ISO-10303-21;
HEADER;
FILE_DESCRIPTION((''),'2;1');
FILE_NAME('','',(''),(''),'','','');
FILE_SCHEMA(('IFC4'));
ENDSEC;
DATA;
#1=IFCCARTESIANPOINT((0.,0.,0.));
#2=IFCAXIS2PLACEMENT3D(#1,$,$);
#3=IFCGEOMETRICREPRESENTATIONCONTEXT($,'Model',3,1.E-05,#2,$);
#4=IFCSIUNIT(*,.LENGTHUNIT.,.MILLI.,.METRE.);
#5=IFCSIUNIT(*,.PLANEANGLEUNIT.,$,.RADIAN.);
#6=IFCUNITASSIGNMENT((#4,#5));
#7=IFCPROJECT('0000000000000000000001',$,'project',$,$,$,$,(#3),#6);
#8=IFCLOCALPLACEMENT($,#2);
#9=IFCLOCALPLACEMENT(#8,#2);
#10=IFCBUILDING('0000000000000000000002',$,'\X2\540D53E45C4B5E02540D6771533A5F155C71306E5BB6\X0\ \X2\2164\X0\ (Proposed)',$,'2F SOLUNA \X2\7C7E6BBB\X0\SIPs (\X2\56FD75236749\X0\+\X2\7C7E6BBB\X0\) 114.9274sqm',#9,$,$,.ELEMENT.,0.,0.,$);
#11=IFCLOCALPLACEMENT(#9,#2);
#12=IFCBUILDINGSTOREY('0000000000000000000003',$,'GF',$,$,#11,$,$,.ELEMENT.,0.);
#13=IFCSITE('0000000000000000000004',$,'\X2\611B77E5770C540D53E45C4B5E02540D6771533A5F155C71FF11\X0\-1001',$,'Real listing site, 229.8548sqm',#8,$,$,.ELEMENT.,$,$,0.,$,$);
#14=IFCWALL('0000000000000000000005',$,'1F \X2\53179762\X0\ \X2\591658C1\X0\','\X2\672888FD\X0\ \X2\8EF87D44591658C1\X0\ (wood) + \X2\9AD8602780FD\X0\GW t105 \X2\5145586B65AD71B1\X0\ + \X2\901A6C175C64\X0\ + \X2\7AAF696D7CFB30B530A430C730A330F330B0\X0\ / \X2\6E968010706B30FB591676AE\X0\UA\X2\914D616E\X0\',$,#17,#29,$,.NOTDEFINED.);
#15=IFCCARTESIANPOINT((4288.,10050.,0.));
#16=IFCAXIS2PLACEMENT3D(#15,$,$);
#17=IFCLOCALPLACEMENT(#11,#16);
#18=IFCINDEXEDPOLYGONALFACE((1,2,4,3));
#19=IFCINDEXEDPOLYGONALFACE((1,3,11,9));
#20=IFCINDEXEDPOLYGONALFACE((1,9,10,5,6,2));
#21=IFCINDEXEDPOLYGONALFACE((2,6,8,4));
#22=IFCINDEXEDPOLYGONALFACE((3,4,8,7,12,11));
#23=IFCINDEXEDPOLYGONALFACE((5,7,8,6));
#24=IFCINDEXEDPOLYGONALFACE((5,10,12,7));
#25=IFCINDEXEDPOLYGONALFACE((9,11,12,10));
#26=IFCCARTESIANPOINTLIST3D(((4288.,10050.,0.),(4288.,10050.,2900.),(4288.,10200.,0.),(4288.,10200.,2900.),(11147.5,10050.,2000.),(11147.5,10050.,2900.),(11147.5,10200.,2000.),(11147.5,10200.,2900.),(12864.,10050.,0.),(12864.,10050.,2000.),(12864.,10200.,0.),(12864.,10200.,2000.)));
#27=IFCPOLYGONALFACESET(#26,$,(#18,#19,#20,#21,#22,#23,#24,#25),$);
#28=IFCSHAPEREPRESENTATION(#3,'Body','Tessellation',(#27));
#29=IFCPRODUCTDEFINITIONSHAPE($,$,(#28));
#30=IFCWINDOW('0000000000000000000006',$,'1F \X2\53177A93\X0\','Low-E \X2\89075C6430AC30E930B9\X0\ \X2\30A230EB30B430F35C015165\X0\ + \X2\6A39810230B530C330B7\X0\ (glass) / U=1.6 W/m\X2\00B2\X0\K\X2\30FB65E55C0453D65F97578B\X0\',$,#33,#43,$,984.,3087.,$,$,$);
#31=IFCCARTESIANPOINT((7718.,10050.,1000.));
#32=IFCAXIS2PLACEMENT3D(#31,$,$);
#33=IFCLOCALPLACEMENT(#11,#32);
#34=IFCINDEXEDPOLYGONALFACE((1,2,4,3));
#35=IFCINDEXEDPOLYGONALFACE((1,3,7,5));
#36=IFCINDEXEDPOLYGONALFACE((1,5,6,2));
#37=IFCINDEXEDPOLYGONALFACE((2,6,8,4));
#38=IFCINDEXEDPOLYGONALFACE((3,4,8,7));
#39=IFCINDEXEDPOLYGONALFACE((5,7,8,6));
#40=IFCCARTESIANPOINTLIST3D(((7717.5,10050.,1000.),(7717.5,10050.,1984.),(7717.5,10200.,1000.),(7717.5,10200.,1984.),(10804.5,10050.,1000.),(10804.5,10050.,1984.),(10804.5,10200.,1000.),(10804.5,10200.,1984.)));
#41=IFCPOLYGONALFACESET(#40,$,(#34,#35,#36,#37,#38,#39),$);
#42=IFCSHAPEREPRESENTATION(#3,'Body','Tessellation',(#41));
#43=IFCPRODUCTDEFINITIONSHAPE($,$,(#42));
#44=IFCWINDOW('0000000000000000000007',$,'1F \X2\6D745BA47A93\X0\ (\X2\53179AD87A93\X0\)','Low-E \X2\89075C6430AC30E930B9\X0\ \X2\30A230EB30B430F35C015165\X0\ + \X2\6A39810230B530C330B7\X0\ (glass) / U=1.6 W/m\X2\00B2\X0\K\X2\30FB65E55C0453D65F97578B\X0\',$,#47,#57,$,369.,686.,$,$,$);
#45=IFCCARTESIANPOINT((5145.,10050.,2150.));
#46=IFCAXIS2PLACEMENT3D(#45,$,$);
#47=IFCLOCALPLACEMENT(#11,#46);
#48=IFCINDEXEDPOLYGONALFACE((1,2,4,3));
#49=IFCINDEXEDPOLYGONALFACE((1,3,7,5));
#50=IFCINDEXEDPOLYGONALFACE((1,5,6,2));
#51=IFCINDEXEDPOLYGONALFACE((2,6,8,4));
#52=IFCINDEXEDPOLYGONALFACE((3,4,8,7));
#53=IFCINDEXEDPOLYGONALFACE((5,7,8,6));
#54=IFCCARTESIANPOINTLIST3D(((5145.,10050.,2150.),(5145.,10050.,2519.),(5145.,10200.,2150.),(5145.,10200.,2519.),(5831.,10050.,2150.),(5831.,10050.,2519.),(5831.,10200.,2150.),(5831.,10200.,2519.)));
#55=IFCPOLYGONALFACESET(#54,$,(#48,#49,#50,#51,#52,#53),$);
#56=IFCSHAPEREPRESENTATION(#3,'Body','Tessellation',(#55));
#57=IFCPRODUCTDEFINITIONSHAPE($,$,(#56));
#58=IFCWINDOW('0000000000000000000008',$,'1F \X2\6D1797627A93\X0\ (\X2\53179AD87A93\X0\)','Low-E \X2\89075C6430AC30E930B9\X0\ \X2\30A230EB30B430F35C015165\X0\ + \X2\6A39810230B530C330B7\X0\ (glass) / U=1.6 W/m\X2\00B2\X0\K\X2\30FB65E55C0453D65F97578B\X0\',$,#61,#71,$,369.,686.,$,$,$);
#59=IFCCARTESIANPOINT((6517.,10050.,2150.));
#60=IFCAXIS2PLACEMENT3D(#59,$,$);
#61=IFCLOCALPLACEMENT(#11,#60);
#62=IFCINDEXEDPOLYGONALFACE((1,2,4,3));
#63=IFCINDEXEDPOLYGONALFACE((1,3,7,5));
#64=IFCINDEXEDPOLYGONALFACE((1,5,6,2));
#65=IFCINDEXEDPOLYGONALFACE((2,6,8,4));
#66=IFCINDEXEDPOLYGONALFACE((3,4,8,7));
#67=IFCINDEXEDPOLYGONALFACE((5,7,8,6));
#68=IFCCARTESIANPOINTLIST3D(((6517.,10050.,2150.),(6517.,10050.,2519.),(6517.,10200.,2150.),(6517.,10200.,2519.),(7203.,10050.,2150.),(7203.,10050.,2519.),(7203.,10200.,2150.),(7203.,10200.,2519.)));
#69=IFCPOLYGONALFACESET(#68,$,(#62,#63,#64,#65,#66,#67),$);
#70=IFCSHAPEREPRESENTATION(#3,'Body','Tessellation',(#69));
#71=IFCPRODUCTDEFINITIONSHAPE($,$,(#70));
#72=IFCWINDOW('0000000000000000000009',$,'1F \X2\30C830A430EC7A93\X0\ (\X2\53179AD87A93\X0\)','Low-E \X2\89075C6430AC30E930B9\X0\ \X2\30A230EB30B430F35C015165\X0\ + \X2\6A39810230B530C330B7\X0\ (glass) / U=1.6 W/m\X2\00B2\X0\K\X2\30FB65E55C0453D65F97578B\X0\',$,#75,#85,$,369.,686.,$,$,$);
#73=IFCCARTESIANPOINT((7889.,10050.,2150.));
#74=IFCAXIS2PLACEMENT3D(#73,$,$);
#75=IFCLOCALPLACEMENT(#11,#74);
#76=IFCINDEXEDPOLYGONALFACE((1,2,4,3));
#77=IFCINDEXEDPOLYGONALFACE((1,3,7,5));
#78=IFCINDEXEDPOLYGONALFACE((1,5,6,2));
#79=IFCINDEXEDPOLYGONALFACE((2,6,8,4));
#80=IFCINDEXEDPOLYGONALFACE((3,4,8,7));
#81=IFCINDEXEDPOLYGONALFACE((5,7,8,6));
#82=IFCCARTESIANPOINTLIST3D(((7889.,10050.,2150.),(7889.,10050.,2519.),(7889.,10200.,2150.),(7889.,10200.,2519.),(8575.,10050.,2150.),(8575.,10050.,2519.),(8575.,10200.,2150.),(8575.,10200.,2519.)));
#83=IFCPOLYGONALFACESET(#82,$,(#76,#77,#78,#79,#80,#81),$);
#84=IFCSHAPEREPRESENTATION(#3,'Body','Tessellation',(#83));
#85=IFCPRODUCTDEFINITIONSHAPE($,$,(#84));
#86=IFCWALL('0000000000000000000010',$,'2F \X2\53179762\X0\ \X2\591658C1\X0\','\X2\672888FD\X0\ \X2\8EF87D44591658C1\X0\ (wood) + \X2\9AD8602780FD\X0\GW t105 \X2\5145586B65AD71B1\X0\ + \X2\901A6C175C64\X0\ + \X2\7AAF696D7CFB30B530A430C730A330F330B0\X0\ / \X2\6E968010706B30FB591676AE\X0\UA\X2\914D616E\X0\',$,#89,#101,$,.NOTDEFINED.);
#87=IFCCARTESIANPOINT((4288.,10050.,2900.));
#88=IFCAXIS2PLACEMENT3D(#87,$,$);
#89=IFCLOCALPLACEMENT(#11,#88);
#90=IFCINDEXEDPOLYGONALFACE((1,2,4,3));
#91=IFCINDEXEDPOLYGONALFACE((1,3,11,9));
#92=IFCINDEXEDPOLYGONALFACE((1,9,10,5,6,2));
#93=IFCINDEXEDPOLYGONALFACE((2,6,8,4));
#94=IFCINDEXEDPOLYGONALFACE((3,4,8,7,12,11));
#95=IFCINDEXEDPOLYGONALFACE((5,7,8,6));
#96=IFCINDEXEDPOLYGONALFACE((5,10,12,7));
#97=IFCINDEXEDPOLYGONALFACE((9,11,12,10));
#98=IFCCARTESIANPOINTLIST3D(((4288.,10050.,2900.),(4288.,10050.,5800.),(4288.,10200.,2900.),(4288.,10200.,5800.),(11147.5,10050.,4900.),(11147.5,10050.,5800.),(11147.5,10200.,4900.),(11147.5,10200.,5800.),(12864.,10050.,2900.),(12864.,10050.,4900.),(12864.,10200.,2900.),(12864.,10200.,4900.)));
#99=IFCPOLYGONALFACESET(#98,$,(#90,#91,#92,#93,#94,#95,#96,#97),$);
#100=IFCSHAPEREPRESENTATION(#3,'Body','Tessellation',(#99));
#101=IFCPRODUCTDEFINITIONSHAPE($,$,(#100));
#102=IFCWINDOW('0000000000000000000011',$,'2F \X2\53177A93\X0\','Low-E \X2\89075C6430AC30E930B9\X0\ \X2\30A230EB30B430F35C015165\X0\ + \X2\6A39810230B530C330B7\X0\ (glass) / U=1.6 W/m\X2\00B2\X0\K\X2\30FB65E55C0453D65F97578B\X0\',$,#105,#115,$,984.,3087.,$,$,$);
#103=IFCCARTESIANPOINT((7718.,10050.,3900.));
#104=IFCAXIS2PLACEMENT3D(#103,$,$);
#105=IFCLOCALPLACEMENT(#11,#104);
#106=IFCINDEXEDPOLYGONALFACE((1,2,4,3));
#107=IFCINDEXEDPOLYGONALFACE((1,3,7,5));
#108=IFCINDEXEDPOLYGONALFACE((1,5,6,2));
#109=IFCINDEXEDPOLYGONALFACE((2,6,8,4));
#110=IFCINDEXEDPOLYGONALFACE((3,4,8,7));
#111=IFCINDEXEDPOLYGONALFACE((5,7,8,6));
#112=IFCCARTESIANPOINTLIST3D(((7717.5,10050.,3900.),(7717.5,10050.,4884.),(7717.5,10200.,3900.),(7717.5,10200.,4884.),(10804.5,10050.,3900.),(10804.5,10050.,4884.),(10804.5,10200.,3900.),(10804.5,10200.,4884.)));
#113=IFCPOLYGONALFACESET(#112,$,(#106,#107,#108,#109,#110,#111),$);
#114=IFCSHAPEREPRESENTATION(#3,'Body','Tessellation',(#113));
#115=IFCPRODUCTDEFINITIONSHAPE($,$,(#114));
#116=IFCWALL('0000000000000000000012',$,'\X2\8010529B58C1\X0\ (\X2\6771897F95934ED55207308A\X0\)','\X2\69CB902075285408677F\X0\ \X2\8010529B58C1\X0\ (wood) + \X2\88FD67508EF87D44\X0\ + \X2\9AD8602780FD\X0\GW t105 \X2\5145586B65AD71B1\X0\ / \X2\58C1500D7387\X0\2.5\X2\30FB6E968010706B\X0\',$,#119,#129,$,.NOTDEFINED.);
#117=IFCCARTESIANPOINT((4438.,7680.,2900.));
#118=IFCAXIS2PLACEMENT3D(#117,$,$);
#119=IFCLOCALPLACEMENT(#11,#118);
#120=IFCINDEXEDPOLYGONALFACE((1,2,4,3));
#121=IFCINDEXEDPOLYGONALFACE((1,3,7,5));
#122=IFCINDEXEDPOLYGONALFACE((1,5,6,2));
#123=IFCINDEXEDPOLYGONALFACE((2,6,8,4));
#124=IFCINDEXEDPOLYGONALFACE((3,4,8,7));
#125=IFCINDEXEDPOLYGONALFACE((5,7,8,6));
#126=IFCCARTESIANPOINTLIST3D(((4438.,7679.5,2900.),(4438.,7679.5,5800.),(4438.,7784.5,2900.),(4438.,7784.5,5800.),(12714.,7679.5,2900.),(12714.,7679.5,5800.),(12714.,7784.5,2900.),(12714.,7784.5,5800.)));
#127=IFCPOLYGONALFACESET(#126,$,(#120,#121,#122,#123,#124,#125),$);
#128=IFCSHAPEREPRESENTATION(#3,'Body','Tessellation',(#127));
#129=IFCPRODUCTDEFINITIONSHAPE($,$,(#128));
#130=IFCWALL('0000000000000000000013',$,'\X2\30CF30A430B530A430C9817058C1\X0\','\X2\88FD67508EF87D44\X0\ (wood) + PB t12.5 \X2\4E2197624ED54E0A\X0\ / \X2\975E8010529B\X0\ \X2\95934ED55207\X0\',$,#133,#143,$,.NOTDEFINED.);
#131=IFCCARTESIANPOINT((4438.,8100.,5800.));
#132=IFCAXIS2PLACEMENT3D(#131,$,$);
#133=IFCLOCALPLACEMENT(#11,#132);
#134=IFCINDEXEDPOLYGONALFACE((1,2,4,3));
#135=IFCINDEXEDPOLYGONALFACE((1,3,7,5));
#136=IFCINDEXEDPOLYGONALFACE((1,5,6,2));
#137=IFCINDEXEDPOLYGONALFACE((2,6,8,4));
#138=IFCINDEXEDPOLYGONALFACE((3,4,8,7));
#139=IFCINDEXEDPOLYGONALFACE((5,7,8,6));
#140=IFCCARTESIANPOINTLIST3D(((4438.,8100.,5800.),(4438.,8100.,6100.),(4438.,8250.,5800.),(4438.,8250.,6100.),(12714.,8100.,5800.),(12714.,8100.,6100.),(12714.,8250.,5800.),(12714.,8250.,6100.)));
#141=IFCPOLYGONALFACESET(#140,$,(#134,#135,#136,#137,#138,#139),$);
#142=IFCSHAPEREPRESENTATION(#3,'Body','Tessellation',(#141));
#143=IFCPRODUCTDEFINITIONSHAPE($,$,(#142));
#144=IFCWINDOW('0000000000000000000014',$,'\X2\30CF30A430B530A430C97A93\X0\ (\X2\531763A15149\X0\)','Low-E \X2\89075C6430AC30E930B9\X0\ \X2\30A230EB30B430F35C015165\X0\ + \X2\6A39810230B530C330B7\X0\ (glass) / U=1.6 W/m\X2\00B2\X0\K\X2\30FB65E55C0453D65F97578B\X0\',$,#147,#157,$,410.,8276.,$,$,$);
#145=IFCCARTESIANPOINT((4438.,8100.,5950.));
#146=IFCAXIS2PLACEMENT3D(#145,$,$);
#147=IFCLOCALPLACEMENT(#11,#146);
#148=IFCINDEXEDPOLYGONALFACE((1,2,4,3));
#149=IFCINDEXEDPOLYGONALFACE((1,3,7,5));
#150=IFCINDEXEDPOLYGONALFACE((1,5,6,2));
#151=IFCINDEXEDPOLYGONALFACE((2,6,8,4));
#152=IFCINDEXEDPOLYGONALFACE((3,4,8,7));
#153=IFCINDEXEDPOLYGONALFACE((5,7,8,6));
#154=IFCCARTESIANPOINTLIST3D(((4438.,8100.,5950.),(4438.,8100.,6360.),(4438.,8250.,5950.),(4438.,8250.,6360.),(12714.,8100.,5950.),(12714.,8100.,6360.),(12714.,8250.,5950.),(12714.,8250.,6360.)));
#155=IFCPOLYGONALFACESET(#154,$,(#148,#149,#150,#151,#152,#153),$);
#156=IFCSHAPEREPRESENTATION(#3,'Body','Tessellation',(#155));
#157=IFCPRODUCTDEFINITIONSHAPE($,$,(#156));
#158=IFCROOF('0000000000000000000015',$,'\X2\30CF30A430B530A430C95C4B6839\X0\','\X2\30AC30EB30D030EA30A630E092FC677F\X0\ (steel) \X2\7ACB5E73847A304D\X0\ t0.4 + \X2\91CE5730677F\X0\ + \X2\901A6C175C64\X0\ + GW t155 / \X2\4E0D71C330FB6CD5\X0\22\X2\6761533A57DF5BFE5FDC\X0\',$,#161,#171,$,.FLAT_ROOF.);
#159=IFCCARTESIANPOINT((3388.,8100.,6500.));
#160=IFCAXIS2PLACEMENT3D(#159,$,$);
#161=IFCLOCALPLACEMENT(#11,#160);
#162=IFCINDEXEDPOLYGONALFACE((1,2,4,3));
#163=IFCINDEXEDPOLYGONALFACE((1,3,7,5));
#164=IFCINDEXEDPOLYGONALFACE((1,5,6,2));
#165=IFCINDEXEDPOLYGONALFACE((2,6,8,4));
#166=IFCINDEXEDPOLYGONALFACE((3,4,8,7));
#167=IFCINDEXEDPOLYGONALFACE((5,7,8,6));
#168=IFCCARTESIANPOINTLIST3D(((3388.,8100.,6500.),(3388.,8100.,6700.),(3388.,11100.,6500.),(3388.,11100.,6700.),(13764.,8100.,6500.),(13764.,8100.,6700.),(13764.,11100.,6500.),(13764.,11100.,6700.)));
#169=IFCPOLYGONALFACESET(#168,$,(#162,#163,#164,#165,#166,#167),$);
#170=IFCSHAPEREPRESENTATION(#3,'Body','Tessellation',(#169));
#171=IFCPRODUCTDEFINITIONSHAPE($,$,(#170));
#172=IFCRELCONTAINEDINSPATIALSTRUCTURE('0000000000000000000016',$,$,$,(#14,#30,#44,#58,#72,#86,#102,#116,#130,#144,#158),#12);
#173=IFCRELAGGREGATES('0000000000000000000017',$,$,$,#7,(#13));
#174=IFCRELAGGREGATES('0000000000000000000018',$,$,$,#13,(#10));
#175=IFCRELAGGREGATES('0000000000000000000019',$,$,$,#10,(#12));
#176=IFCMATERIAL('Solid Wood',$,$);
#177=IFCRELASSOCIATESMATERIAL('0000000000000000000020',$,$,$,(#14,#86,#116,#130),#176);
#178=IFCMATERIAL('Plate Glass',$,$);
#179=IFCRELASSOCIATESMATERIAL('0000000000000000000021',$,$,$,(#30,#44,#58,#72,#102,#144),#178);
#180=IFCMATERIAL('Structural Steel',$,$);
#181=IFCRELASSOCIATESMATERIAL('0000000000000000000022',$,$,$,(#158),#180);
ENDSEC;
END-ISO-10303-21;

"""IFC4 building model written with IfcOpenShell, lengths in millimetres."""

from ifc_helpers import new_model, si_unit, frame, frame_2d, origin, place, context, project, spatial, rectangle, extrude, material, element, fill, save


model = new_model("IFC4")

# Units and contexts
model_context = context("Model", 3, precision=1e-05, world=origin())
ifc_project = project(units=[si_unit("LENGTHUNIT", "METRE", prefix="MILLI"), si_unit("PLANEANGLEUNIT", "RADIAN")], contexts=[model_context])

# Site, building, storey
site_placement = place(None, origin())
site = spatial("IfcSite", under=ifc_project, at=site_placement, Name="愛知県名古屋市名東区引山１-1001", ObjectType="Real listing site, 229.8548sqm", CompositionType="ELEMENT", RefElevation=0.0)
building_placement = place(site_placement, origin())
building = spatial("IfcBuilding", under=site, at=building_placement, Name="名古屋市名東区引山の家 Ⅴ (Proposed)", ObjectType="2F SOLUNA 籾殻SIPs (国産杉+籾殻) 114.9274sqm", CompositionType="ELEMENT", ElevationOfRefHeight=0.0, ElevationOfTerrain=0.0)
storey_placement = place(building_placement, origin())
storey = spatial("IfcBuildingStorey", under=building, at=storey_placement, Name="GF", CompositionType="ELEMENT", Elevation=0.0)

# Wall, openings, windows
ifc_material_1 = material(Name="Solid Wood")
wall_1_placement = place(storey_placement, frame((4288.0, 10050.0, 0.0)))
wall_1 = element("IfcWall", 1, at=wall_1_placement, inside=storey, material=ifc_material_1, Name="1F 北面 外壁", Description="木製 軸組外壁 (wood) + 高性能GW t105 充填断熱 + 通気層 + 窯業系サイディング / 準耐火・外皮UA配慮", PredefinedType="NOTDEFINED", context=model_context, shape_type="SweptSolid", body=[
    extrude(rectangle(XDim=8576.0, YDim=150.0, at=frame_2d((4288.0, 75.0))), frame((4288.0, 10050.0, 0.0)), (0.0, 0.0, 1.0), 2900.0),
])
opening_1_placement = place(storey_placement, frame((7718.0, 10050.0, 1000.0)))
opening_1 = element("IfcOpeningElement", 2, at=opening_1_placement, cuts=wall_1, PredefinedType="NOTDEFINED", context=model_context, shape_type="SweptSolid", body=[
    extrude(rectangle(XDim=3087.0, YDim=150.0, at=frame_2d((1543.0, 75.0))), frame((7718.0, 10050.0, 1000.0)), (0.0, 0.0, 1.0), 984.0),
])
opening_2_placement = place(storey_placement, frame((5145.0, 10050.0, 2150.0)))
opening_2 = element("IfcOpeningElement", 3, at=opening_2_placement, cuts=wall_1, PredefinedType="NOTDEFINED", context=model_context, shape_type="SweptSolid", body=[
    extrude(rectangle(XDim=686.0, YDim=150.0, at=frame_2d((343.0, 75.0))), frame((5145.0, 10050.0, 2150.0)), (0.0, 0.0, 1.0), 369.0),
])
opening_3_placement = place(storey_placement, frame((6517.0, 10050.0, 2150.0)))
opening_3 = element("IfcOpeningElement", 4, at=opening_3_placement, cuts=wall_1, PredefinedType="NOTDEFINED", context=model_context, shape_type="SweptSolid", body=[
    extrude(rectangle(XDim=686.0, YDim=150.0, at=frame_2d((343.0, 75.0))), frame((6517.0, 10050.0, 2150.0)), (0.0, 0.0, 1.0), 369.0),
])
opening_4_placement = place(storey_placement, frame((7889.0, 10050.0, 2150.0)))
opening_4 = element("IfcOpeningElement", 5, at=opening_4_placement, cuts=wall_1, PredefinedType="NOTDEFINED", context=model_context, shape_type="SweptSolid", body=[
    extrude(rectangle(XDim=686.0, YDim=150.0, at=frame_2d((343.0, 75.0))), frame((7889.0, 10050.0, 2150.0)), (0.0, 0.0, 1.0), 369.0),
])
ifc_material_2 = material(Name="Plate Glass")
window_1_placement = place(storey_placement, frame((7718.0, 10050.0, 1000.0)))
window_1 = element("IfcWindow", 6, at=window_1_placement, inside=storey, material=ifc_material_2, Name="1F 北窓", Description="Low-E 複層ガラス アルゴン封入 + 樹脂サッシ (glass) / U=1.6 W/m²K・日射取得型", OverallHeight=984.0, OverallWidth=3087.0, context=model_context, shape_type="SweptSolid", body=[
    extrude(rectangle(XDim=3087.0, YDim=150.0, at=frame_2d((1543.0, 75.0))), frame((7718.0, 10050.0, 1000.0)), (0.0, 0.0, 1.0), 984.0),
])
fill(opening_1, window_1)
window_2_placement = place(storey_placement, frame((5145.0, 10050.0, 2150.0)))
window_2 = element("IfcWindow", 7, at=window_2_placement, inside=storey, material=ifc_material_2, Name="1F 浴室窓 (北高窓)", Description="Low-E 複層ガラス アルゴン封入 + 樹脂サッシ (glass) / U=1.6 W/m²K・日射取得型", OverallHeight=369.0, OverallWidth=686.0, context=model_context, shape_type="SweptSolid", body=[
    extrude(rectangle(XDim=686.0, YDim=150.0, at=frame_2d((343.0, 75.0))), frame((5145.0, 10050.0, 2150.0)), (0.0, 0.0, 1.0), 369.0),
])
fill(opening_2, window_2)
window_3_placement = place(storey_placement, frame((6517.0, 10050.0, 2150.0)))
window_3 = element("IfcWindow", 8, at=window_3_placement, inside=storey, material=ifc_material_2, Name="1F 洗面窓 (北高窓)", Description="Low-E 複層ガラス アルゴン封入 + 樹脂サッシ (glass) / U=1.6 W/m²K・日射取得型", OverallHeight=369.0, OverallWidth=686.0, context=model_context, shape_type="SweptSolid", body=[
    extrude(rectangle(XDim=686.0, YDim=150.0, at=frame_2d((343.0, 75.0))), frame((6517.0, 10050.0, 2150.0)), (0.0, 0.0, 1.0), 369.0),
])
fill(opening_3, window_3)
window_4_placement = place(storey_placement, frame((7889.0, 10050.0, 2150.0)))
window_4 = element("IfcWindow", 9, at=window_4_placement, inside=storey, material=ifc_material_2, Name="1F トイレ窓 (北高窓)", Description="Low-E 複層ガラス アルゴン封入 + 樹脂サッシ (glass) / U=1.6 W/m²K・日射取得型", OverallHeight=369.0, OverallWidth=686.0, context=model_context, shape_type="SweptSolid", body=[
    extrude(rectangle(XDim=686.0, YDim=150.0, at=frame_2d((343.0, 75.0))), frame((7889.0, 10050.0, 2150.0)), (0.0, 0.0, 1.0), 369.0),
])
fill(opening_4, window_4)

# Wall, opening, window
wall_2_placement = place(storey_placement, frame((4288.0, 10050.0, 2900.0)))
wall_2 = element("IfcWall", 10, at=wall_2_placement, inside=storey, material=ifc_material_1, Name="2F 北面 外壁", Description="木製 軸組外壁 (wood) + 高性能GW t105 充填断熱 + 通気層 + 窯業系サイディング / 準耐火・外皮UA配慮", PredefinedType="NOTDEFINED", context=model_context, shape_type="SweptSolid", body=[
    extrude(rectangle(XDim=8576.0, YDim=150.0, at=frame_2d((4288.0, 75.0))), frame((4288.0, 10050.0, 2900.0)), (0.0, 0.0, 1.0), 2900.0),
])
opening_5_placement = place(storey_placement, frame((7718.0, 10050.0, 3900.0)))
opening_5 = element("IfcOpeningElement", 11, at=opening_5_placement, cuts=wall_2, PredefinedType="NOTDEFINED", context=model_context, shape_type="SweptSolid", body=[
    extrude(rectangle(XDim=3087.0, YDim=150.0, at=frame_2d((1543.0, 75.0))), frame((7718.0, 10050.0, 3900.0)), (0.0, 0.0, 1.0), 984.0),
])
window_5_placement = place(storey_placement, frame((7718.0, 10050.0, 3900.0)))
window_5 = element("IfcWindow", 12, at=window_5_placement, inside=storey, material=ifc_material_2, Name="2F 北窓", Description="Low-E 複層ガラス アルゴン封入 + 樹脂サッシ (glass) / U=1.6 W/m²K・日射取得型", OverallHeight=984.0, OverallWidth=3087.0, context=model_context, shape_type="SweptSolid", body=[
    extrude(rectangle(XDim=3087.0, YDim=150.0, at=frame_2d((1543.0, 75.0))), frame((7718.0, 10050.0, 3900.0)), (0.0, 0.0, 1.0), 984.0),
])
fill(opening_5, window_5)

# Wall
wall_3_placement = place(storey_placement, frame((4438.0, 7680.0, 2900.0)))
element("IfcWall", 13, at=wall_3_placement, inside=storey, material=ifc_material_1, Name="耐力壁 (東西間仕切り)", Description="構造用合板 耐力壁 (wood) + 製材軸組 + 高性能GW t105 充填断熱 / 壁倍率2.5・準耐火", PredefinedType="NOTDEFINED", context=model_context, shape_type="SweptSolid", body=[
    extrude(rectangle(XDim=8276.0, YDim=105.0, at=frame_2d((4138.0, 52.0))), frame((4438.0, 7680.0, 2900.0)), (0.0, 0.0, 1.0), 2900.0),
])

# Wall, opening, window
wall_4_placement = place(storey_placement, frame((4438.0, 8100.0, 5800.0)))
wall_4 = element("IfcWall", 14, at=wall_4_placement, inside=storey, material=ifc_material_1, Name="ハイサイド腰壁", Description="製材軸組 (wood) + PB t12.5 両面仕上 / 非耐力 間仕切", PredefinedType="NOTDEFINED", context=model_context, shape_type="SweptSolid", body=[
    extrude(rectangle(XDim=8276.0, YDim=150.0, at=frame_2d((4138.0, 75.0))), frame((4438.0, 8100.0, 5800.0)), (0.0, 0.0, 1.0), 700.0),
])
opening_6_placement = place(storey_placement, frame((4438.0, 8100.0, 5950.0)))
opening_6 = element("IfcOpeningElement", 15, at=opening_6_placement, cuts=wall_4, PredefinedType="NOTDEFINED", context=model_context, shape_type="SweptSolid", body=[
    extrude(rectangle(XDim=8276.0, YDim=150.0, at=frame_2d((4138.0, 75.0))), frame((4438.0, 8100.0, 5950.0)), (0.0, 0.0, 1.0), 410.0),
])
window_6_placement = place(storey_placement, frame((4438.0, 8100.0, 5950.0)))
window_6 = element("IfcWindow", 16, at=window_6_placement, inside=storey, material=ifc_material_2, Name="ハイサイド窓 (北採光)", Description="Low-E 複層ガラス アルゴン封入 + 樹脂サッシ (glass) / U=1.6 W/m²K・日射取得型", OverallHeight=410.0, OverallWidth=8276.0, context=model_context, shape_type="SweptSolid", body=[
    extrude(rectangle(XDim=8276.0, YDim=150.0, at=frame_2d((4138.0, 75.0))), frame((4438.0, 8100.0, 5950.0)), (0.0, 0.0, 1.0), 410.0),
])
fill(opening_6, window_6)

# Roof
ifc_material_3 = material(Name="Structural Steel")
roof_placement = place(storey_placement, frame((3388.0, 8100.0, 6500.0)))
element("IfcRoof", 17, at=roof_placement, inside=storey, material=ifc_material_3, Name="ハイサイド屋根", Description="ガルバリウム鋼板 (steel) 立平葺き t0.4 + 野地板 + 通気層 + GW t155 / 不燃・法22条区域対応", PredefinedType="FLAT_ROOF", context=model_context, shape_type="SweptSolid", body=[
    extrude(rectangle(XDim=10376.0, YDim=3000.0, at=frame_2d((5188.0, 1500.0))), frame((3388.0, 8100.0, 6500.0)), (0.0, 0.0, 1.0), 200.0),
])

save(model, "model.ifc")
